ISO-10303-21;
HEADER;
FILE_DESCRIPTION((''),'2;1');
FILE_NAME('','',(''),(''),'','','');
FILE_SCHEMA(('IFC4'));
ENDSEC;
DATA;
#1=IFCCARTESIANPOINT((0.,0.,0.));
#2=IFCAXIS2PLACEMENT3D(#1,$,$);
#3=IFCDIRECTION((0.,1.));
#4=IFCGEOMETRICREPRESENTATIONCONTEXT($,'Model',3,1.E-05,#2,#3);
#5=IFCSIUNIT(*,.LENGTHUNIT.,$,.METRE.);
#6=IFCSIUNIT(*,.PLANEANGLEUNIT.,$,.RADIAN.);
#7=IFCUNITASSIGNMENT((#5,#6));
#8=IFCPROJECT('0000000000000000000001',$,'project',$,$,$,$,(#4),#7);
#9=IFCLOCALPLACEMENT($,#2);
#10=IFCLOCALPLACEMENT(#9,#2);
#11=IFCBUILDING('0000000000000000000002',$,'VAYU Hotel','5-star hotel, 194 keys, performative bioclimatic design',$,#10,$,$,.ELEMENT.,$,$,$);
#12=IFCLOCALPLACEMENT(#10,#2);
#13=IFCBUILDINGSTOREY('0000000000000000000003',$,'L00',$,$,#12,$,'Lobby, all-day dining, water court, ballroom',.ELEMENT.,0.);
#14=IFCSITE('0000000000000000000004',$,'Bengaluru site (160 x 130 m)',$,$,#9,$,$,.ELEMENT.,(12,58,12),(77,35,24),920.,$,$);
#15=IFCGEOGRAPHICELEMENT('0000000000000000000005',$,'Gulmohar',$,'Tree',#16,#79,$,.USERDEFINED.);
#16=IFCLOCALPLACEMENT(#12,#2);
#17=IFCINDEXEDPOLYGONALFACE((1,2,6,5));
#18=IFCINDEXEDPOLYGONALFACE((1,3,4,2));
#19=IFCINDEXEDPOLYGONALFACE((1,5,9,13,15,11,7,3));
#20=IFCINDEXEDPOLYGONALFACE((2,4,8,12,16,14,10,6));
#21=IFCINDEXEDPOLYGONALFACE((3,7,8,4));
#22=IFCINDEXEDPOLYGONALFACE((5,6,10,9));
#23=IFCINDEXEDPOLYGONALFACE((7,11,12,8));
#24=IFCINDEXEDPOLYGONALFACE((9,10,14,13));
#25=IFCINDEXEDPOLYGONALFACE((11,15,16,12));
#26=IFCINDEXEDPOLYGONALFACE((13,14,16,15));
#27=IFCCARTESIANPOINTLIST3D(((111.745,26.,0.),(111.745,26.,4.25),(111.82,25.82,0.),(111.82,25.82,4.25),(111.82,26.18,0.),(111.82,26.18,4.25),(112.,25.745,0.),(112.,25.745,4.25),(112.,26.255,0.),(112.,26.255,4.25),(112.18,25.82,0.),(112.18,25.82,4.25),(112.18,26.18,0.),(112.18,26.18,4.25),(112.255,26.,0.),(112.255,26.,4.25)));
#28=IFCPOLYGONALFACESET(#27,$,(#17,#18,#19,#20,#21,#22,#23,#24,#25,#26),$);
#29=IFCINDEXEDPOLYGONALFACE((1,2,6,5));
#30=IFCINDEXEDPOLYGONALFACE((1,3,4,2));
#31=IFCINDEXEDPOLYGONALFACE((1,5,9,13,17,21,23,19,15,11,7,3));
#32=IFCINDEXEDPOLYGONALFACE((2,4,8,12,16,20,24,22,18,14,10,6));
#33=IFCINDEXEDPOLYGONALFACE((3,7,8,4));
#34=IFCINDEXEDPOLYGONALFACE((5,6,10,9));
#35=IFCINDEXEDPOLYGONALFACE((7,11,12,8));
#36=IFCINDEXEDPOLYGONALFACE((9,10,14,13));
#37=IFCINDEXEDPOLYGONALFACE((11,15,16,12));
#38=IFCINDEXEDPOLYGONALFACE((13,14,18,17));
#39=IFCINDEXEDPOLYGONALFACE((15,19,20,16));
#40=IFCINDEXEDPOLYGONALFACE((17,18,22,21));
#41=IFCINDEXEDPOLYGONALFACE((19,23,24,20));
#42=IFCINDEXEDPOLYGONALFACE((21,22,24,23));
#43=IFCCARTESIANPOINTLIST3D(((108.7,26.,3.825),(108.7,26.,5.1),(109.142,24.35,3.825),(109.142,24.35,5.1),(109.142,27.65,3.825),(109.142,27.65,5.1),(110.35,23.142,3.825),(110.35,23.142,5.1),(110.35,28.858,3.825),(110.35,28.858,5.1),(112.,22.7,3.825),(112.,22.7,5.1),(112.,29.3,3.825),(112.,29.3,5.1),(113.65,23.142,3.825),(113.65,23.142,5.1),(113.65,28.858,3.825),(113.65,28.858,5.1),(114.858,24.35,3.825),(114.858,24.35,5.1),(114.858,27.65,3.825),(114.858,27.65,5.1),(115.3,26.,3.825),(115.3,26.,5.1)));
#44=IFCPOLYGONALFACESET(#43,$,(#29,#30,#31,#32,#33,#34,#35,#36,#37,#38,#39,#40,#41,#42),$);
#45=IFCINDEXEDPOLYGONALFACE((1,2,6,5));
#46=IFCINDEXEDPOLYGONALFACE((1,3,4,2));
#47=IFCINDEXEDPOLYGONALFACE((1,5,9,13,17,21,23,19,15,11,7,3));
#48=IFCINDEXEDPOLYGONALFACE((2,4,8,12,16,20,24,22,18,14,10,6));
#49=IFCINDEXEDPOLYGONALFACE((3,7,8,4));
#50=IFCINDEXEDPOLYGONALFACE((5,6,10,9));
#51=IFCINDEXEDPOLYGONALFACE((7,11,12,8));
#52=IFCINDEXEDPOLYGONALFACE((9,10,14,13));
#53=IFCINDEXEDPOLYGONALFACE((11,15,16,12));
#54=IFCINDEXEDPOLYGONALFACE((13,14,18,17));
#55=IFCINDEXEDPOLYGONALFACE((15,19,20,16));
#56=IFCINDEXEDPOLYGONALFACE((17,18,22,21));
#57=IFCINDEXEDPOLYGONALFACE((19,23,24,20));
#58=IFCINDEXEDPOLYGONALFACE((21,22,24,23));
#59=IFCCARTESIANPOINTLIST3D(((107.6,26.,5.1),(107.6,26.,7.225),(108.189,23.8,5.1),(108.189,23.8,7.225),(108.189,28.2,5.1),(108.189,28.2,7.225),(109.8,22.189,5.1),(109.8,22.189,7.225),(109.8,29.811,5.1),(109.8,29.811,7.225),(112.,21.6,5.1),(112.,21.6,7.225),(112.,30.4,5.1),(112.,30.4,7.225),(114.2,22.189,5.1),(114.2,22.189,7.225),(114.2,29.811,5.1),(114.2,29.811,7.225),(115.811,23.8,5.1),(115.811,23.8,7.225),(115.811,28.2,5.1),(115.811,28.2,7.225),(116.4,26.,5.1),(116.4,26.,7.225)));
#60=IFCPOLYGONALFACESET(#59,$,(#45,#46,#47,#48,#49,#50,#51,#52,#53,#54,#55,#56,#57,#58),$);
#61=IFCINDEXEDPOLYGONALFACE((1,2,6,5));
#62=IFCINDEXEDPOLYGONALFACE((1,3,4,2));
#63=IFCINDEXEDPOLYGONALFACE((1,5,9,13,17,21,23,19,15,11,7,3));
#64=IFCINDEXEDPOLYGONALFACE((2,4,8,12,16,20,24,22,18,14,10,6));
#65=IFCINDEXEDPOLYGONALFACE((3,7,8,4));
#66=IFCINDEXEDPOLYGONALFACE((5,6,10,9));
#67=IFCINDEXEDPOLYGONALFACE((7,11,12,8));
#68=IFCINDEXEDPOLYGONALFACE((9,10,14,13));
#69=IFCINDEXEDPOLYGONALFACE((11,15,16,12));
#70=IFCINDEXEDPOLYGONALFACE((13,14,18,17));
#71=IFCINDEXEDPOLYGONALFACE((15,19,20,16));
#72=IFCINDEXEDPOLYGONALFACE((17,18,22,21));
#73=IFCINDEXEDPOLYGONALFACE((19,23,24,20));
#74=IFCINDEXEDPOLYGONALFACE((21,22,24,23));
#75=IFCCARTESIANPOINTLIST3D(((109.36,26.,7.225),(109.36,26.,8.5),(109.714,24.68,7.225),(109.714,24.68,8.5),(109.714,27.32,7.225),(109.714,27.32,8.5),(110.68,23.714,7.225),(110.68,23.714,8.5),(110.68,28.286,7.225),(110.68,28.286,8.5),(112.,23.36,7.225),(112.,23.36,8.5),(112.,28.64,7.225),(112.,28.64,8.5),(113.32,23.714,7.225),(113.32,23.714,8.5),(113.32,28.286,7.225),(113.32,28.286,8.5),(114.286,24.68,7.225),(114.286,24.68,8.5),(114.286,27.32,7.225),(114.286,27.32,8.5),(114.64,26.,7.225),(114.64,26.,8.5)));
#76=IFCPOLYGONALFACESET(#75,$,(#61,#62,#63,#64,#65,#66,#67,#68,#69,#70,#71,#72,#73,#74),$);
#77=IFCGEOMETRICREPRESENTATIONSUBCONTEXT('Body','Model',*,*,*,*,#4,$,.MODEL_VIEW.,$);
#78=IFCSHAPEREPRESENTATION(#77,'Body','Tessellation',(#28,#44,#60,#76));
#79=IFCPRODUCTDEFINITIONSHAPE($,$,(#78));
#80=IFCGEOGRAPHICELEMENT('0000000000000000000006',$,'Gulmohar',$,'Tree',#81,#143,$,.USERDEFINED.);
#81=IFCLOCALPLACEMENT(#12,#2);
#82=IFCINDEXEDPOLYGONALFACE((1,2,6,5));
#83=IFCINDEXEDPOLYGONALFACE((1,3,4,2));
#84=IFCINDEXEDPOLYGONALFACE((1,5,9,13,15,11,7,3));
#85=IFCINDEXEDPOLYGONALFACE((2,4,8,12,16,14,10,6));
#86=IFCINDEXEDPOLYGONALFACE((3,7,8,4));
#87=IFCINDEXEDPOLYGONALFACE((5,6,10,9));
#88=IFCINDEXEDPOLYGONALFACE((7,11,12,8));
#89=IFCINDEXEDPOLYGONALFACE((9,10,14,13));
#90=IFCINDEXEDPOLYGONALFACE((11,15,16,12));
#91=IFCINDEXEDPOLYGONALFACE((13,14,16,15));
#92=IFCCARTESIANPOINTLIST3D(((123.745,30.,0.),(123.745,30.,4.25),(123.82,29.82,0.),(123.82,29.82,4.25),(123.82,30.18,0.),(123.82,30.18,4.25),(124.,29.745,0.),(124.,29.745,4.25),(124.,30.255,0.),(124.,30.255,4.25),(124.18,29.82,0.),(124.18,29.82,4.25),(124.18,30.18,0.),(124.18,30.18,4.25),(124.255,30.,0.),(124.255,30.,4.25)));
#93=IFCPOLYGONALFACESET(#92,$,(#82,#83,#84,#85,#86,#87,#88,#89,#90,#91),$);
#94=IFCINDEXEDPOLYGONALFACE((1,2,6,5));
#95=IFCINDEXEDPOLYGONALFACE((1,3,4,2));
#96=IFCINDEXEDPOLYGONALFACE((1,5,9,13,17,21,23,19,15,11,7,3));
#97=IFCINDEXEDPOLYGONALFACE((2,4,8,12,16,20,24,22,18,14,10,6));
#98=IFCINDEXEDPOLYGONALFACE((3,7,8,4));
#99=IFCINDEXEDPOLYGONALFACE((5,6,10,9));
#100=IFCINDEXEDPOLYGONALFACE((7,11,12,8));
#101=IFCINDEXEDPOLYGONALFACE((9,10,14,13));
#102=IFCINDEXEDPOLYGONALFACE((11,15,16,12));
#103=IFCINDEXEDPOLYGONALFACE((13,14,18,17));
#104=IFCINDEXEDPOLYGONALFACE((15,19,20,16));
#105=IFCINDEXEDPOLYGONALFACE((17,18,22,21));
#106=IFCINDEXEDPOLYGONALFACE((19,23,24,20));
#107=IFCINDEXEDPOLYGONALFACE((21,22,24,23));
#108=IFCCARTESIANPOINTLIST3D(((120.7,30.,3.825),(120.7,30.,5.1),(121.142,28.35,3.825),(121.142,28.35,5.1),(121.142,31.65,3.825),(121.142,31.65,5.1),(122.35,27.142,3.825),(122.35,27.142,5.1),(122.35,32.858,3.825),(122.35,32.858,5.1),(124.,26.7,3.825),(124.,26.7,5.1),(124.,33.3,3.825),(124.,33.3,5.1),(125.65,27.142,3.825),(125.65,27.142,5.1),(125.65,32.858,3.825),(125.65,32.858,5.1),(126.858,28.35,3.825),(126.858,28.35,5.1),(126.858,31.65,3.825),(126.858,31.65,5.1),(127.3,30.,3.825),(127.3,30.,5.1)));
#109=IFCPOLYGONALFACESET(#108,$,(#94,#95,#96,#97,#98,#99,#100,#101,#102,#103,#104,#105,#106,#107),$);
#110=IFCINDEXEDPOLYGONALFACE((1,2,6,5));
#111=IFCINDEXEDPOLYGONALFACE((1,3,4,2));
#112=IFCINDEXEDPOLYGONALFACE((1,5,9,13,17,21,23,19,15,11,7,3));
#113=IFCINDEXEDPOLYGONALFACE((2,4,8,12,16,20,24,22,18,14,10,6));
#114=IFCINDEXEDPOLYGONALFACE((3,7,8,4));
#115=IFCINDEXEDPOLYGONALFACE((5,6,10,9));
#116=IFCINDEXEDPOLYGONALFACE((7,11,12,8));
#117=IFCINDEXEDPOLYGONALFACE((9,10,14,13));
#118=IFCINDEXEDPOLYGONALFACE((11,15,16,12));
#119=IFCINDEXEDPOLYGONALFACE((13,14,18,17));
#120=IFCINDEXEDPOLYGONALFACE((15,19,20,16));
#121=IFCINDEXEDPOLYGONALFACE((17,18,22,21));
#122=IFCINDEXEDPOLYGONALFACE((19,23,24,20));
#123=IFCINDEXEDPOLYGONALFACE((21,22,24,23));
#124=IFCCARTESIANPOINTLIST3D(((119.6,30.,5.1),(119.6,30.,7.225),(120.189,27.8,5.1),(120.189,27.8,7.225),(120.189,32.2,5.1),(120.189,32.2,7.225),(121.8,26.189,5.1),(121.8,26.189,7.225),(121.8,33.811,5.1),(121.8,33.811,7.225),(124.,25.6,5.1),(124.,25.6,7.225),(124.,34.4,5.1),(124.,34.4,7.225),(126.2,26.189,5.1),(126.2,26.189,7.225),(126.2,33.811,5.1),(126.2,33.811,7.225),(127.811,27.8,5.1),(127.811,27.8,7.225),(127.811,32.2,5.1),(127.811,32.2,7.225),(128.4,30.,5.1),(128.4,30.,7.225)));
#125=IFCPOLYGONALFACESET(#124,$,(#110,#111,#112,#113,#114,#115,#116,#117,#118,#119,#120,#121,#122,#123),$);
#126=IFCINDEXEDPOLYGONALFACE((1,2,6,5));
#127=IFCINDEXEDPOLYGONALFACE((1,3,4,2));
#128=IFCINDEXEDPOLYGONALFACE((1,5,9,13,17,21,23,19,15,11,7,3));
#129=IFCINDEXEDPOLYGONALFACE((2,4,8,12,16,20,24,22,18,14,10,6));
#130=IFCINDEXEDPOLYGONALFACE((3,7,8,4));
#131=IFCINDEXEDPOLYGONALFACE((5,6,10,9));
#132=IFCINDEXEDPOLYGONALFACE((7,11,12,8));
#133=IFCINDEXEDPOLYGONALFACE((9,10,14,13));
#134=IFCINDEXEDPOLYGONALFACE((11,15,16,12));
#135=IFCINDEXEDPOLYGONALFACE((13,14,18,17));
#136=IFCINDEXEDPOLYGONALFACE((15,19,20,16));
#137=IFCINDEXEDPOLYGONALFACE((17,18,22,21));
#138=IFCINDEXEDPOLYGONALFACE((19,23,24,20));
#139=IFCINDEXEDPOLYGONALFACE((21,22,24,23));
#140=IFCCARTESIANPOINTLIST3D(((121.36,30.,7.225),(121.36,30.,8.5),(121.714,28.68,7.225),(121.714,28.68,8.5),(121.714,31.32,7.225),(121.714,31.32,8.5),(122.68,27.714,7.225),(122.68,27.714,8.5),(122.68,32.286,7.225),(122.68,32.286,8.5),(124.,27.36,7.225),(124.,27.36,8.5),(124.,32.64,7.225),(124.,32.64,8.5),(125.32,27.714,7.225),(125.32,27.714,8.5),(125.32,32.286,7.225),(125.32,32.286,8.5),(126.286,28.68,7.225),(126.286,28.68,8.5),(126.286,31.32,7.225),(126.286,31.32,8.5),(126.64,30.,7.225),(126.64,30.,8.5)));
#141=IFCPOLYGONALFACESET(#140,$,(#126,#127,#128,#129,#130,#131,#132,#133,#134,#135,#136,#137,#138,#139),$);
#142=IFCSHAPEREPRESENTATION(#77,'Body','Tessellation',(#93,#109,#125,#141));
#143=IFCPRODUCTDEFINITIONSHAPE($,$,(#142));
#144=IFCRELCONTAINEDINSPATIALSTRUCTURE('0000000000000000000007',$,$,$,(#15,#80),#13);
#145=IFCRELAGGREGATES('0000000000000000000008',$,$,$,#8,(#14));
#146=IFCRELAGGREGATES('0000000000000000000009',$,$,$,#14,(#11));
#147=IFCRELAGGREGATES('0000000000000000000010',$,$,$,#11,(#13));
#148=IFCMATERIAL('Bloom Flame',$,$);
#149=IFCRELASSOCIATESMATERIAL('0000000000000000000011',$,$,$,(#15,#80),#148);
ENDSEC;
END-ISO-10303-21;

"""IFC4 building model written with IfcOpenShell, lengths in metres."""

from ifc_helpers import new_model, si_unit, direction, frame, origin, place, context, subcontext, project, spatial, polyline, outline, extrude, material, element, save


model = new_model("IFC4")

# Units and contexts
model_context = context("Model", 3, precision=1e-05, world=origin(), true_north=direction((0.0, 1.0)))
body_context = subcontext(model_context, "Body", "Model", "MODEL_VIEW")
ifc_project = project(units=[si_unit("LENGTHUNIT", "METRE"), si_unit("PLANEANGLEUNIT", "RADIAN")], contexts=[model_context])

# Site, building, storey
site_placement = place(None, origin())
site = spatial("IfcSite", under=ifc_project, at=site_placement, Name="Bengaluru site (160 x 130 m)", CompositionType="ELEMENT", RefLatitude=(12, 58, 12), RefLongitude=(77, 35, 24), RefElevation=920.0)
building_placement = place(site_placement, origin())
building = spatial("IfcBuilding", under=site, at=building_placement, Name="VAYU Hotel", Description="5-star hotel, 194 keys, performative bioclimatic design", CompositionType="ELEMENT")
storey_placement = place(building_placement, origin())
storey = spatial("IfcBuildingStorey", under=building, at=storey_placement, Name="L00", LongName="Lobby, all-day dining, water court, ballroom", CompositionType="ELEMENT", Elevation=0.0)

# Geographic elements
ifc_material_1 = material(Name="Bloom Flame")
geographic_element_1_placement = place(storey_placement, origin())
element("IfcGeographicElement", 1, at=geographic_element_1_placement, inside=storey, material=ifc_material_1, Name="Gulmohar", ObjectType="Tree", PredefinedType="USERDEFINED", context=body_context, shape_type="SweptSolid", body=[
    extrude(outline(polyline([(112.255, 26.0), (112.18, 26.18), (112.0, 26.255), (111.82, 26.18), (111.745, 26.0), (111.82, 25.82), (112.0, 25.745), (112.18, 25.82), (112.255, 26.0)])), origin(), (0.0, 0.0, 1.0), 4.25),
    extrude(outline(polyline([(115.3, 26.0), (114.858, 27.65), (113.65, 28.858), (112.0, 29.3), (110.35, 28.858), (109.142, 27.65), (108.7, 26.0), (109.142, 24.35), (110.35, 23.142), (112.0, 22.7), (113.65, 23.142), (114.858, 24.35), (115.3, 26.0)])), frame((0.0, 0.0, 3.825)), (0.0, 0.0, 1.0), 1.275),
    extrude(outline(polyline([(116.4, 26.0), (115.811, 28.2), (114.2, 29.811), (112.0, 30.4), (109.8, 29.811), (108.189, 28.2), (107.6, 26.0), (108.189, 23.8), (109.8, 22.189), (112.0, 21.6), (114.2, 22.189), (115.811, 23.8), (116.4, 26.0)])), frame((0.0, 0.0, 5.1)), (0.0, 0.0, 1.0), 2.125),
    extrude(outline(polyline([(114.64, 26.0), (114.286, 27.32), (113.32, 28.286), (112.0, 28.64), (110.68, 28.286), (109.714, 27.32), (109.36, 26.0), (109.714, 24.68), (110.68, 23.714), (112.0, 23.36), (113.32, 23.714), (114.286, 24.68), (114.64, 26.0)])), frame((0.0, 0.0, 7.225)), (0.0, 0.0, 1.0), 1.275),
])
geographic_element_2_placement = place(storey_placement, origin())
element("IfcGeographicElement", 2, at=geographic_element_2_placement, inside=storey, material=ifc_material_1, Name="Gulmohar", ObjectType="Tree", PredefinedType="USERDEFINED", context=body_context, shape_type="SweptSolid", body=[
    extrude(outline(polyline([(124.255, 30.0), (124.18, 30.18), (124.0, 30.255), (123.82, 30.18), (123.745, 30.0), (123.82, 29.82), (124.0, 29.745), (124.18, 29.82), (124.255, 30.0)])), origin(), (0.0, 0.0, 1.0), 4.25),
    extrude(outline(polyline([(127.3, 30.0), (126.858, 31.65), (125.65, 32.858), (124.0, 33.3), (122.35, 32.858), (121.142, 31.65), (120.7, 30.0), (121.142, 28.35), (122.35, 27.142), (124.0, 26.7), (125.65, 27.142), (126.858, 28.35), (127.3, 30.0)])), frame((0.0, 0.0, 3.825)), (0.0, 0.0, 1.0), 1.275),
    extrude(outline(polyline([(128.4, 30.0), (127.811, 32.2), (126.2, 33.811), (124.0, 34.4), (121.8, 33.811), (120.189, 32.2), (119.6, 30.0), (120.189, 27.8), (121.8, 26.189), (124.0, 25.6), (126.2, 26.189), (127.811, 27.8), (128.4, 30.0)])), frame((0.0, 0.0, 5.1)), (0.0, 0.0, 1.0), 2.125),
    extrude(outline(polyline([(126.64, 30.0), (126.286, 31.32), (125.32, 32.286), (124.0, 32.64), (122.68, 32.286), (121.714, 31.32), (121.36, 30.0), (121.714, 28.68), (122.68, 27.714), (124.0, 27.36), (125.32, 27.714), (126.286, 28.68), (126.64, 30.0)])), frame((0.0, 0.0, 7.225)), (0.0, 0.0, 1.0), 1.275),
])

save(model, "model.ifc")
